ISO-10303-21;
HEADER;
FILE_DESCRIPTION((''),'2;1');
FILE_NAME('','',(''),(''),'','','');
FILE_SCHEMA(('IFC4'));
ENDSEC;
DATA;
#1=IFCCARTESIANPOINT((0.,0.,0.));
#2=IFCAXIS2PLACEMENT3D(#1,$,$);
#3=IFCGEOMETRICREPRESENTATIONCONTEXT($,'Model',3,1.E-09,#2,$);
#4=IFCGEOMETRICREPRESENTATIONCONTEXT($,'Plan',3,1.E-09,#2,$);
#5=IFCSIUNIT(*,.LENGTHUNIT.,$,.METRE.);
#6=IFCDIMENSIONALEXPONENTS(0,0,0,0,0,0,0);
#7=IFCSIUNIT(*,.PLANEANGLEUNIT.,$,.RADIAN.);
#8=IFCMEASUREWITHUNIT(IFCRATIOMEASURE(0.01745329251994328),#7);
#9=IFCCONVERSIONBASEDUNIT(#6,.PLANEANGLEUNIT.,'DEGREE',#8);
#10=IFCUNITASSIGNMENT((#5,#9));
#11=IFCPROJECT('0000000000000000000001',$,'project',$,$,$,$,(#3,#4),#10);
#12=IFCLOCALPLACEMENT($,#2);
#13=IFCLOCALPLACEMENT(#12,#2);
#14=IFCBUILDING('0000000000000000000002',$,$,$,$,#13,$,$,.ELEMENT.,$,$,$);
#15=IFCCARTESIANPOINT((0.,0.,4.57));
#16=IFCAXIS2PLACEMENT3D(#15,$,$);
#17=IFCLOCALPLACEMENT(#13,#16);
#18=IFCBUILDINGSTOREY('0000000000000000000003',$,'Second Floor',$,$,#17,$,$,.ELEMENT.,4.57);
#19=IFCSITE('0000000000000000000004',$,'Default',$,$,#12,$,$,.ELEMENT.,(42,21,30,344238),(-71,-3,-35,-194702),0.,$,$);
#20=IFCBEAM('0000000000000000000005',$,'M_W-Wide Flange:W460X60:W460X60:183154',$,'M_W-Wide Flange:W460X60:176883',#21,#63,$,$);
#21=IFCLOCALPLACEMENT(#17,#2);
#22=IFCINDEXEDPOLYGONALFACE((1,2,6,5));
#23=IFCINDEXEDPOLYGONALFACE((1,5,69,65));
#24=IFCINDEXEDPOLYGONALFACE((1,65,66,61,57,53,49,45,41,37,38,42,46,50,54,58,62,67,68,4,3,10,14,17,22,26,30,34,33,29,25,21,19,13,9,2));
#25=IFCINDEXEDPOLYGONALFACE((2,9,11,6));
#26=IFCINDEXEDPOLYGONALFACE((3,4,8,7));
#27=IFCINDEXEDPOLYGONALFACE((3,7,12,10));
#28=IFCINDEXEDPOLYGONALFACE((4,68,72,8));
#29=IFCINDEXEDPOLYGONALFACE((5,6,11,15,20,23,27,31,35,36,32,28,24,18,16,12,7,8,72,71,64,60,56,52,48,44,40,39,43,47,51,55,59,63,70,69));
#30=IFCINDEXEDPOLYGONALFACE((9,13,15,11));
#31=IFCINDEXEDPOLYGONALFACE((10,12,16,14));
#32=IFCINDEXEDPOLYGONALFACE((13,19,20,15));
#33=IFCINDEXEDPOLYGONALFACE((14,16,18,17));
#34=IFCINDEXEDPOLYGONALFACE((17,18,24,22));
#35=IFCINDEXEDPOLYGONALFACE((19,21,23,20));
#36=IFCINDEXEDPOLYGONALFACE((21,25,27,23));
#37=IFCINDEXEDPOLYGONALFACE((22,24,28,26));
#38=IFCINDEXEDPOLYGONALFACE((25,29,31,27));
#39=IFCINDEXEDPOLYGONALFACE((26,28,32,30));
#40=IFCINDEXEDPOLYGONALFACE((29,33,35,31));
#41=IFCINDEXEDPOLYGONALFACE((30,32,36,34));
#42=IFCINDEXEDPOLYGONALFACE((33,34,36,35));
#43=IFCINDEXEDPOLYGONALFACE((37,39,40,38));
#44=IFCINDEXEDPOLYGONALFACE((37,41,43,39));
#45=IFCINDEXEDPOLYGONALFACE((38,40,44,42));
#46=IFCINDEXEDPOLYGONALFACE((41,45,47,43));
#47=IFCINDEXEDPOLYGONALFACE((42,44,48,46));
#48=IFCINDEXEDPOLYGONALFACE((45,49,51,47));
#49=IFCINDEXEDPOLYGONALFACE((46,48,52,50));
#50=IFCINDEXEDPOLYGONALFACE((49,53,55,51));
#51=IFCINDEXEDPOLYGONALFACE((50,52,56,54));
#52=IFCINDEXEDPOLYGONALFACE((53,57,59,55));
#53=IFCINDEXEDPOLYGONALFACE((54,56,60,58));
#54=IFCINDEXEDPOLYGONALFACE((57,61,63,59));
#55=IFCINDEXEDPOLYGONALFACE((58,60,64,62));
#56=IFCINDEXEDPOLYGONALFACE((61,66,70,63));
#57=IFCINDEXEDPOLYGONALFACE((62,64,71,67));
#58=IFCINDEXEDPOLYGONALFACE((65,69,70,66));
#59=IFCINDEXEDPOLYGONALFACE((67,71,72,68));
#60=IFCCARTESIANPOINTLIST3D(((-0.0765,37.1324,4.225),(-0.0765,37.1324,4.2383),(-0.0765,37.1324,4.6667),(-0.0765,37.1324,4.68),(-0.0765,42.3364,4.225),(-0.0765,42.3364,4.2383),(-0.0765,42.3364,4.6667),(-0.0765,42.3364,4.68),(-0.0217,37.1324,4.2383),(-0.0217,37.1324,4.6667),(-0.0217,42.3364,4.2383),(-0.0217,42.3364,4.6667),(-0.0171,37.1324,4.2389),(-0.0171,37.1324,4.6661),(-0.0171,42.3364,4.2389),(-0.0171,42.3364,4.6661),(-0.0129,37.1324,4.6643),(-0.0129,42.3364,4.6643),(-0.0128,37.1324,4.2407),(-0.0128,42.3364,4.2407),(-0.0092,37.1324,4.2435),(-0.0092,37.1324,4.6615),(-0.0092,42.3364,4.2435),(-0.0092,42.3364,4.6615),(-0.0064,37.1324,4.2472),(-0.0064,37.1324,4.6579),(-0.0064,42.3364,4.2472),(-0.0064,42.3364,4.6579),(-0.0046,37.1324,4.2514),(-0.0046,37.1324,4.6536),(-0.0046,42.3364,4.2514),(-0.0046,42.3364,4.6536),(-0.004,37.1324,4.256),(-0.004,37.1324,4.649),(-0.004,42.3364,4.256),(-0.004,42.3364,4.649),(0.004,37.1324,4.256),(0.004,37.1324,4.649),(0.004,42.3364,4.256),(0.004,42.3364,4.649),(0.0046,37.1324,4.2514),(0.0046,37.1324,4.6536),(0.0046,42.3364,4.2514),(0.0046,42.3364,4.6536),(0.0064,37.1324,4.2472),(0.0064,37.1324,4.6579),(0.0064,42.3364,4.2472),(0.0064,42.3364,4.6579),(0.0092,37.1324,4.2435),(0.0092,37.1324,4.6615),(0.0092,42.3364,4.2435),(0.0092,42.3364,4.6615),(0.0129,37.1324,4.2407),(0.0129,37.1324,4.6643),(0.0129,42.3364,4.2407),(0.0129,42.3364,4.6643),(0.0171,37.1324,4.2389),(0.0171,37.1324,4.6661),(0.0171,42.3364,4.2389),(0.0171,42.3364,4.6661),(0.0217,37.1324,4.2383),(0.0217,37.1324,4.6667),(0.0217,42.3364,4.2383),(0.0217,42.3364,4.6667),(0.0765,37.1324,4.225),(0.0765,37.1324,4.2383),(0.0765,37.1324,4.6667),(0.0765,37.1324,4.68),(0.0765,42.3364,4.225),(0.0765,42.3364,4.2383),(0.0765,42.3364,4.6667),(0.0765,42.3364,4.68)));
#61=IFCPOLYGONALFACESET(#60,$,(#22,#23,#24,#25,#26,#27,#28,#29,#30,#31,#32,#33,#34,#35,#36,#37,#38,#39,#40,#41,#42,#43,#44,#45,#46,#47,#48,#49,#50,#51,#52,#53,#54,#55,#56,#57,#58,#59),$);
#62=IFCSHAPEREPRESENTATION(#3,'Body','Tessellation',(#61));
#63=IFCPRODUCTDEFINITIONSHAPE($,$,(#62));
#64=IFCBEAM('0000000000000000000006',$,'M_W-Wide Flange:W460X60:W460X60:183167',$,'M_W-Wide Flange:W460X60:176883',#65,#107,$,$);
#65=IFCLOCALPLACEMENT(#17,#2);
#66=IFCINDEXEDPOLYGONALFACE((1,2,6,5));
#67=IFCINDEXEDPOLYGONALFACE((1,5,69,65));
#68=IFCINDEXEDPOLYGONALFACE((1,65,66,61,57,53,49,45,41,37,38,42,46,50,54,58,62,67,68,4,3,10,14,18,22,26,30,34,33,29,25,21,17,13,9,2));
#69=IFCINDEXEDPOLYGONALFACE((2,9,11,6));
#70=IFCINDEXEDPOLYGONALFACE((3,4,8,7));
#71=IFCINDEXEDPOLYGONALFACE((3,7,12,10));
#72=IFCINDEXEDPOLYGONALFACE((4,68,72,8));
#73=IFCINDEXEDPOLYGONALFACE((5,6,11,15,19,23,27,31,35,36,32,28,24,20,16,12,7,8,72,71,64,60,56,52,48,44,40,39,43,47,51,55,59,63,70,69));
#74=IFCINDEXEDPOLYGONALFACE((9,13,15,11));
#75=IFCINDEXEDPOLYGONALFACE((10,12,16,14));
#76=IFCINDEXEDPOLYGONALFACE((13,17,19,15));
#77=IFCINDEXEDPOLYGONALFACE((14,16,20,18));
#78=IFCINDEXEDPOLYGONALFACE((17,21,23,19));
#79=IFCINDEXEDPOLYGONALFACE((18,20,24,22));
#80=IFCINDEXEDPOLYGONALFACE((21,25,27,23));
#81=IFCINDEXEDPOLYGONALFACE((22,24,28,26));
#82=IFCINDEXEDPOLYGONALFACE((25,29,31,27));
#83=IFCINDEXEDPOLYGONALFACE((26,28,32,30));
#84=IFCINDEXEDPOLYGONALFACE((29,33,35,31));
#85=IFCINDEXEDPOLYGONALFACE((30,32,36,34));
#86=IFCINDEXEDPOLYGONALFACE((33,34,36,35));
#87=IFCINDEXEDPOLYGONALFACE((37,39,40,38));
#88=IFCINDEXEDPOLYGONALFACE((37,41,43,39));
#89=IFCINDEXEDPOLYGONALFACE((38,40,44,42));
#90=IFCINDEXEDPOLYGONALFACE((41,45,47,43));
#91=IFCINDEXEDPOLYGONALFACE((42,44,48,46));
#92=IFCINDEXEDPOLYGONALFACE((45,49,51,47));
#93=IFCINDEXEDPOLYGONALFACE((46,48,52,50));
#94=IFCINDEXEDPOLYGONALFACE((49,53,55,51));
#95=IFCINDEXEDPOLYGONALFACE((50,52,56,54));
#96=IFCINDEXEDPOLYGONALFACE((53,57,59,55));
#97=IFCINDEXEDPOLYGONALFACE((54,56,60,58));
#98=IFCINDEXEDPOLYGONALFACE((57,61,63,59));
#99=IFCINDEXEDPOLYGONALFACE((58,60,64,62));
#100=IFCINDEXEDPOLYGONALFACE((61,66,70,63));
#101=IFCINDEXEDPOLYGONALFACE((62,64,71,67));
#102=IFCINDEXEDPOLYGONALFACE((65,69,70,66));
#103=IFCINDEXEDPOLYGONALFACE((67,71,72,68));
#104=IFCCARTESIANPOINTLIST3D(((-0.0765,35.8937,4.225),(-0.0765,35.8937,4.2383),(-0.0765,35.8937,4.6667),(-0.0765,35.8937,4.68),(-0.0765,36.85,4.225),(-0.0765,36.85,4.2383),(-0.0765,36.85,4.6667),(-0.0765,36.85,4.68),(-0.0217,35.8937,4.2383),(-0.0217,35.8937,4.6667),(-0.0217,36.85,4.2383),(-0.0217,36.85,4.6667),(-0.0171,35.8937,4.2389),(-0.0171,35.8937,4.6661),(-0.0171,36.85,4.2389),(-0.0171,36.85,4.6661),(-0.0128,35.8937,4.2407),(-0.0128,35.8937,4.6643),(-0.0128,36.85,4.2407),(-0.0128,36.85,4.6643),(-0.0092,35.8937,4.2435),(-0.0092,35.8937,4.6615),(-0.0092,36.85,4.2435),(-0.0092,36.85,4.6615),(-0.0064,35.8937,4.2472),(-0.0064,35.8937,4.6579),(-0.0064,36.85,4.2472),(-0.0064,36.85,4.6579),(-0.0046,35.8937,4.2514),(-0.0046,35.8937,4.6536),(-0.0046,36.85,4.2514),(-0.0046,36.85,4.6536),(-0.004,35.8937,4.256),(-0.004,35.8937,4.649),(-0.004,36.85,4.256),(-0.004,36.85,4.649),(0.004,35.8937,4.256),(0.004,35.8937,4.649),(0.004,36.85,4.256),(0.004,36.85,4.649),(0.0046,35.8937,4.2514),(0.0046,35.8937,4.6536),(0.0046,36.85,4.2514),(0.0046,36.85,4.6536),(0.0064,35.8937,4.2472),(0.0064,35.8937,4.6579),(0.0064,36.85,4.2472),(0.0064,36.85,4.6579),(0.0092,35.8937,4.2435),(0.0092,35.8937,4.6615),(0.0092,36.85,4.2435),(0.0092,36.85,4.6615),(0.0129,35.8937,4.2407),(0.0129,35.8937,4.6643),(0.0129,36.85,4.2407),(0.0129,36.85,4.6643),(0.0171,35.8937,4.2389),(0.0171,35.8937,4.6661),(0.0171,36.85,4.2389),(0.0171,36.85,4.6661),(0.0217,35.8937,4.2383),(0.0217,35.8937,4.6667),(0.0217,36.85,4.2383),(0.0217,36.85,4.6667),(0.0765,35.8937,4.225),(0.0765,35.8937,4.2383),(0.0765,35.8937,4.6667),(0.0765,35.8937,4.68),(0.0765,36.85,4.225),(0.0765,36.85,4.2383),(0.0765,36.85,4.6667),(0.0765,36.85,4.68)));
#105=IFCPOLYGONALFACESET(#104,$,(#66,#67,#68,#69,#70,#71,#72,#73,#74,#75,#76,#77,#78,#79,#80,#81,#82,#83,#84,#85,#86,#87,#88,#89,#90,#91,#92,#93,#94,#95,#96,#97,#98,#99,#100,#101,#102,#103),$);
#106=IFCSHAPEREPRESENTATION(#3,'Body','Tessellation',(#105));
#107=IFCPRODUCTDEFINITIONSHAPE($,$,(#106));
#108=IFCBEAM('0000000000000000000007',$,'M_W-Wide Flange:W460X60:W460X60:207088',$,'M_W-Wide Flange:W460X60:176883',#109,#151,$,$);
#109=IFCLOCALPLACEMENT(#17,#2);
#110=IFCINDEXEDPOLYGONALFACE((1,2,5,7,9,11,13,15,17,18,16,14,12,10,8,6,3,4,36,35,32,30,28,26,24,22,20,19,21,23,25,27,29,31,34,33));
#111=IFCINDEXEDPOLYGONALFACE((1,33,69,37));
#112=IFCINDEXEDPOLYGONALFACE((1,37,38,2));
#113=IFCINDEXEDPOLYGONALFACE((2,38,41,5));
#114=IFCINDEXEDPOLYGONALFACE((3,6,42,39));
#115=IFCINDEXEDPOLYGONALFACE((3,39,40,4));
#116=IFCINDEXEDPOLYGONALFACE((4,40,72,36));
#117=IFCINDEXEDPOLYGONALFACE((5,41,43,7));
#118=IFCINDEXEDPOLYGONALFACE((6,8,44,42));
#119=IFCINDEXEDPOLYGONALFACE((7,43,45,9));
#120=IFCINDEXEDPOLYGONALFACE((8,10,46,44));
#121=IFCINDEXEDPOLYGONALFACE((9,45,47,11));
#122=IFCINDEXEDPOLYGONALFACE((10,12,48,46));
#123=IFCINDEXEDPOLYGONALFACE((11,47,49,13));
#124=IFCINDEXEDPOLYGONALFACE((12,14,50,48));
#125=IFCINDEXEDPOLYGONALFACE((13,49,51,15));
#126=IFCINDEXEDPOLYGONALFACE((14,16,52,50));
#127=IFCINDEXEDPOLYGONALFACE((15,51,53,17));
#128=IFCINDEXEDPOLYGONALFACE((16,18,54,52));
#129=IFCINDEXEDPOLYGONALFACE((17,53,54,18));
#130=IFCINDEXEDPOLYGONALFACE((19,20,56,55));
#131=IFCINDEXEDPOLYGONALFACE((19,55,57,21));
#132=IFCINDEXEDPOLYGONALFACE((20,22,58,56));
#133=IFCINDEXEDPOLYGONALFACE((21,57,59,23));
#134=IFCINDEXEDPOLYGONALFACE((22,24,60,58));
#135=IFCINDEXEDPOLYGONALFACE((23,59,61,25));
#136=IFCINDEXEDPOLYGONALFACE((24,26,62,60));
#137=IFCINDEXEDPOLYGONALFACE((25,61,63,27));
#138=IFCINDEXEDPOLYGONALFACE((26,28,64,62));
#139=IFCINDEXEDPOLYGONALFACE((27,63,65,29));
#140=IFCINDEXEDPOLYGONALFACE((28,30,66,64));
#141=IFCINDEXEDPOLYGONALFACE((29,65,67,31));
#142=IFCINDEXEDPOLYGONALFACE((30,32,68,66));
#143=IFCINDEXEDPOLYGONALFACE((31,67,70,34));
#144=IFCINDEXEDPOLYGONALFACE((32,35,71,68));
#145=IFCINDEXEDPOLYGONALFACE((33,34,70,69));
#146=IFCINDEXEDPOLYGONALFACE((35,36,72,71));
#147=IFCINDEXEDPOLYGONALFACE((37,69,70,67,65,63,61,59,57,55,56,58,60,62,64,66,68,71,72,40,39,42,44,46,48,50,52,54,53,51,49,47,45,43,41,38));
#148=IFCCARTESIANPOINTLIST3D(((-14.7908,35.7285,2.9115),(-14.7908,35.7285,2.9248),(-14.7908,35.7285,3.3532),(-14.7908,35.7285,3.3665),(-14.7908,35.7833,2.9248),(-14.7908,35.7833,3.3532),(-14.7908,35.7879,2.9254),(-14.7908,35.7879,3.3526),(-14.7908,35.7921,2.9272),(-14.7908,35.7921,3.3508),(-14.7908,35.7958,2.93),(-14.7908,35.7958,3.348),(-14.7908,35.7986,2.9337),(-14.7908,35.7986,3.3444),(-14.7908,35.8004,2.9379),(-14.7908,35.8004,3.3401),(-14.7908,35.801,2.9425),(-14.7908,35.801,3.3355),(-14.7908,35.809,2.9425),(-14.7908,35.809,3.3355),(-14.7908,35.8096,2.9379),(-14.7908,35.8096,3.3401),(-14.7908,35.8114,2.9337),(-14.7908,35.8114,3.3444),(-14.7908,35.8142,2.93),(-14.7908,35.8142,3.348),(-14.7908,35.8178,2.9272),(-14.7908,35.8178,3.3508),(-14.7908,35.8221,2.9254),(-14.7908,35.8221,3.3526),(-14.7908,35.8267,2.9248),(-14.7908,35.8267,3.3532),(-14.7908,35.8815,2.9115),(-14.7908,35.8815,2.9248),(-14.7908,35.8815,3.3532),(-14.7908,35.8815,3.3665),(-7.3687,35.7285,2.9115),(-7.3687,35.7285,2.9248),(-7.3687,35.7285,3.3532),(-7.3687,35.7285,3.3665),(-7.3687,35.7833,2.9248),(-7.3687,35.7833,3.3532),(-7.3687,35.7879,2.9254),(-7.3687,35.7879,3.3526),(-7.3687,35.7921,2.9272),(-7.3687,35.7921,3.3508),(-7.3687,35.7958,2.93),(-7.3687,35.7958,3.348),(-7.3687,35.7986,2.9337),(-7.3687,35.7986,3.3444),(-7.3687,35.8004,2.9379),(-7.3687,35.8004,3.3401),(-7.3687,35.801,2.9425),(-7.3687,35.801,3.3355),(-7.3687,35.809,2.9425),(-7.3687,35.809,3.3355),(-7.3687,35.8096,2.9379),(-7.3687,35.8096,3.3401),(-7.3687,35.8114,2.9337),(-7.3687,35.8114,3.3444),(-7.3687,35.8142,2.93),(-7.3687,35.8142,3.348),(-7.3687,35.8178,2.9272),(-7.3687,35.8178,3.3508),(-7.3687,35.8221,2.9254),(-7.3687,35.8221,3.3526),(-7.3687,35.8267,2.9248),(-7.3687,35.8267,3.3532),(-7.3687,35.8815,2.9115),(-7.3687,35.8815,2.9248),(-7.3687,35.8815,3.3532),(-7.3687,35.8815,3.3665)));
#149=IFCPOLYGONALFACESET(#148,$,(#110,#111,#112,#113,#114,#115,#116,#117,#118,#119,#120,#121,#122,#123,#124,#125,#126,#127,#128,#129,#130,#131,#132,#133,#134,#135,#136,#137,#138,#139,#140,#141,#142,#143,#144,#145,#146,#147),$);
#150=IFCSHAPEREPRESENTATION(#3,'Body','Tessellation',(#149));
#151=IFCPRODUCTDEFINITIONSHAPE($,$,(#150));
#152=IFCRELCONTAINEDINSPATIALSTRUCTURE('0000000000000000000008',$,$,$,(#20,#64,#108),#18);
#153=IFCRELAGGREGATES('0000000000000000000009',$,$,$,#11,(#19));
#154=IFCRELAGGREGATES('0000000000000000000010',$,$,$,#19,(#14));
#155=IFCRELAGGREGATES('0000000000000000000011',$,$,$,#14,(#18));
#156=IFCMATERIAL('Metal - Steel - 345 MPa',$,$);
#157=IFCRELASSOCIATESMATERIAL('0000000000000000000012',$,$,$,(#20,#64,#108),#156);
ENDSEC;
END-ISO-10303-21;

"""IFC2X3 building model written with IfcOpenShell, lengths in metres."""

from ifc_helpers import new_model, entity, si_unit, converted_unit, frame, frame_2d, origin, place, context, project, spatial, polyline, circle_curve, parameter, trimmed, segment, composite_curve, outline, extrude, material, element, save


model = new_model("IFC2X3")

# Units and contexts
model_context = context("Model", 3, precision=1e-09, world=origin())
plan_context = context("Plan", 3, precision=1e-09, world=origin())
ifc_project = project(units=[si_unit("LENGTHUNIT", "METRE"), converted_unit("PLANEANGLEUNIT", "DEGREE", entity("IfcRatioMeasure", 0.01745329251994328), si_unit("PLANEANGLEUNIT", "RADIAN"), dimensions=[0, 0, 0, 0, 0, 0, 0])], contexts=[model_context, plan_context])

# Site, building, storey
site_placement = place(None, origin())
site = spatial("IfcSite", under=ifc_project, at=site_placement, Name="Default", CompositionType="ELEMENT", RefLatitude=(42, 21, 30, 344238), RefLongitude=(-71, -3, -35, -194702), RefElevation=0.0)
building_placement = place(site_placement, origin())
building = spatial("IfcBuilding", under=site, at=building_placement, CompositionType="ELEMENT")
storey_placement = place(building_placement, frame((0.0, 0.0, 4.57)))
storey = spatial("IfcBuildingStorey", under=building, at=storey_placement, Name="Second Floor", CompositionType="ELEMENT", Elevation=4.57)

# Shared definitions
ifc_material = material(Name="Metal - Steel - 345 MPa")

# Beams
beam_1_placement = place(storey_placement, frame((0.0, 42.4742, 4.68), z_axis=(0.0, 0.0, 1.0), x_axis=(-1.0, 0.0, 0.0)))
element("IfcBeam", 1, at=beam_1_placement, inside=storey, material=ifc_material, Name="M_W-Wide Flange:W460X60:W460X60:183154", ObjectType="M_W-Wide Flange:W460X60:176883", context=model_context, shape_type="SweptSolid", body=[
    extrude(outline(composite_curve([segment(polyline([(0.2142, -0.0765), (0.2275, -0.0765)]), True, "CONTINUOUS"), segment(polyline([(0.2275, -0.0765), (0.2275, 0.0765)]), True, "CONTINUOUS"), segment(polyline([(0.2275, 0.0765), (0.2142, 0.0765)]), True, "CONTINUOUS"), segment(polyline([(0.2142, 0.0765), (0.2142, 0.0217)]), True, "CONTINUOUS"), segment(trimmed(circle_curve(frame_2d((0.1965, 0.0217), x_axis=(1.0, 0.0)), 0.0177), [parameter(270.0)], [parameter(360.0)], True, "PARAMETER"), False, "CONTINUOUS"), segment(polyline([(0.1965, 0.004), (-0.1965, 0.004)]), True, "CONTINUOUS"), segment(trimmed(circle_curve(frame_2d((-0.1965, 0.0217), x_axis=(0.0, -1.0)), 0.0177), [parameter(270.0)], [parameter(360.0)], True, "PARAMETER"), False, "CONTINUOUS"), segment(polyline([(-0.2142, 0.0217), (-0.2142, 0.0765)]), True, "CONTINUOUS"), segment(polyline([(-0.2142, 0.0765), (-0.2275, 0.0765)]), True, "CONTINUOUS"), segment(polyline([(-0.2275, 0.0765), (-0.2275, -0.0765)]), True, "CONTINUOUS"), segment(polyline([(-0.2275, -0.0765), (-0.2142, -0.0765)]), True, "CONTINUOUS"), segment(polyline([(-0.2142, -0.0765), (-0.2142, -0.0217)]), True, "CONTINUOUS"), segment(trimmed(circle_curve(frame_2d((-0.1965, -0.0217), x_axis=(-1.0, 0.0)), 0.0177), [parameter(270.0)], [parameter(360.0)], True, "PARAMETER"), False, "CONTINUOUS"), segment(polyline([(-0.1965, -0.004), (0.1965, -0.004)]), True, "CONTINUOUS"), segment(trimmed(circle_curve(frame_2d((0.1965, -0.0217), x_axis=(0.0, 1.0)), 0.0177), [parameter(270.0)], [parameter(0.0)], True, "PARAMETER"), False, "CONTINUOUS"), segment(polyline([(0.2142, -0.0217), (0.2142, -0.0765)]), True, "CONTINUOUS")], self_intersect=False)), frame((0.0, 5.3418, -0.2275), z_axis=(0.0, -1.0, 0.0), x_axis=(0.0, 0.0, -1.0)), (0.0, 0.0, 1.0), 5.204),
])
beam_2_placement = place(storey_placement, frame((0.0, 36.98, 4.68), z_axis=(0.0, 0.0, 1.0), x_axis=(-1.0, 0.0, 0.0)))
element("IfcBeam", 2, at=beam_2_placement, inside=storey, material=ifc_material, Name="M_W-Wide Flange:W460X60:W460X60:183167", ObjectType="M_W-Wide Flange:W460X60:176883", context=model_context, shape_type="SweptSolid", body=[
    extrude(outline(composite_curve([segment(polyline([(0.2142, -0.0765), (0.2275, -0.0765)]), True, "CONTINUOUS"), segment(polyline([(0.2275, -0.0765), (0.2275, 0.0765)]), True, "CONTINUOUS"), segment(polyline([(0.2275, 0.0765), (0.2142, 0.0765)]), True, "CONTINUOUS"), segment(polyline([(0.2142, 0.0765), (0.2142, 0.0217)]), True, "CONTINUOUS"), segment(trimmed(circle_curve(frame_2d((0.1965, 0.0217), x_axis=(0.0, 1.0)), 0.0177), [parameter(180.0)], [parameter(270.0)], True, "PARAMETER"), False, "CONTINUOUS"), segment(polyline([(0.1965, 0.004), (-0.1965, 0.004)]), True, "CONTINUOUS"), segment(trimmed(circle_curve(frame_2d((-0.1965, 0.0217), x_axis=(0.0, 1.0)), 0.0177), [parameter(90.0)], [parameter(180.0)], True, "PARAMETER"), False, "CONTINUOUS"), segment(polyline([(-0.2142, 0.0217), (-0.2142, 0.0765)]), True, "CONTINUOUS"), segment(polyline([(-0.2142, 0.0765), (-0.2275, 0.0765)]), True, "CONTINUOUS"), segment(polyline([(-0.2275, 0.0765), (-0.2275, -0.0765)]), True, "CONTINUOUS"), segment(polyline([(-0.2275, -0.0765), (-0.2142, -0.0765)]), True, "CONTINUOUS"), segment(polyline([(-0.2142, -0.0765), (-0.2142, -0.0217)]), True, "CONTINUOUS"), segment(trimmed(circle_curve(frame_2d((-0.1965, -0.0217), x_axis=(0.0, 1.0)), 0.0177), [parameter(360.0)], [parameter(90.0)], True, "PARAMETER"), False, "CONTINUOUS"), segment(polyline([(-0.1965, -0.004), (0.1965, -0.004)]), True, "CONTINUOUS"), segment(trimmed(circle_curve(frame_2d((0.1965, -0.0217), x_axis=(0.0, 1.0)), 0.0177), [parameter(270.0)], [parameter(0.0)], True, "PARAMETER"), False, "CONTINUOUS"), segment(polyline([(0.2142, -0.0217), (0.2142, -0.0765)]), True, "CONTINUOUS")], self_intersect=False)), frame((0.0, 1.0863, -0.2275), z_axis=(0.0, -1.0, 0.0), x_axis=(0.0, 0.0, -1.0)), (0.0, 0.0, 1.0), 0.9563),
])
beam_3_placement = place(storey_placement, frame((-7.2774, 35.805, 3.3665), z_axis=(0.0, 0.0, 1.0), x_axis=(0.0, -1.0, 0.0)))
element("IfcBeam", 3, at=beam_3_placement, inside=storey, material=ifc_material, Name="M_W-Wide Flange:W460X60:W460X60:207088", ObjectType="M_W-Wide Flange:W460X60:176883", context=model_context, shape_type="SweptSolid", body=[
    extrude(outline(composite_curve([segment(polyline([(-0.0765, -0.2142), (-0.0765, -0.2275)]), True, "CONTINUOUS"), segment(polyline([(-0.0765, -0.2275), (0.0765, -0.2275)]), True, "CONTINUOUS"), segment(polyline([(0.0765, -0.2275), (0.0765, -0.2142)]), True, "CONTINUOUS"), segment(polyline([(0.0765, -0.2142), (0.0217, -0.2142)]), True, "CONTINUOUS"), segment(trimmed(circle_curve(frame_2d((0.0217, -0.1965), x_axis=(1.0, 0.0)), 0.0177), [parameter(180.0)], [parameter(270.0)], True, "PARAMETER"), False, "CONTINUOUS"), segment(polyline([(0.004, -0.1965), (0.004, 0.1965)]), True, "CONTINUOUS"), segment(trimmed(circle_curve(frame_2d((0.0217, 0.1965), x_axis=(1.0, 0.0)), 0.0177), [parameter(90.0)], [parameter(180.0)], True, "PARAMETER"), False, "CONTINUOUS"), segment(polyline([(0.0217, 0.2142), (0.0765, 0.2142)]), True, "CONTINUOUS"), segment(polyline([(0.0765, 0.2142), (0.0765, 0.2275)]), True, "CONTINUOUS"), segment(polyline([(0.0765, 0.2275), (-0.0765, 0.2275)]), True, "CONTINUOUS"), segment(polyline([(-0.0765, 0.2275), (-0.0765, 0.2142)]), True, "CONTINUOUS"), segment(polyline([(-0.0765, 0.2142), (-0.0217, 0.2142)]), True, "CONTINUOUS"), segment(trimmed(circle_curve(frame_2d((-0.0217, 0.1965), x_axis=(1.0, 0.0)), 0.0177), [parameter(360.0)], [parameter(90.0)], True, "PARAMETER"), False, "CONTINUOUS"), segment(polyline([(-0.004, 0.1965), (-0.004, -0.1965)]), True, "CONTINUOUS"), segment(trimmed(circle_curve(frame_2d((-0.0217, -0.1965), x_axis=(1.0, 0.0)), 0.0177), [parameter(270.0)], [parameter(0.0)], True, "PARAMETER"), False, "CONTINUOUS"), segment(polyline([(-0.0217, -0.2142), (-0.0765, -0.2142)]), True, "CONTINUOUS")], self_intersect=False)), frame((0.0, -7.5134, -0.2275), z_axis=(0.0, -1.0, 0.0), x_axis=(1.0, 0.0, 0.0)), (0.0, 0.0, -1.0), 7.4221),
])

save(model, "model.ifc")
